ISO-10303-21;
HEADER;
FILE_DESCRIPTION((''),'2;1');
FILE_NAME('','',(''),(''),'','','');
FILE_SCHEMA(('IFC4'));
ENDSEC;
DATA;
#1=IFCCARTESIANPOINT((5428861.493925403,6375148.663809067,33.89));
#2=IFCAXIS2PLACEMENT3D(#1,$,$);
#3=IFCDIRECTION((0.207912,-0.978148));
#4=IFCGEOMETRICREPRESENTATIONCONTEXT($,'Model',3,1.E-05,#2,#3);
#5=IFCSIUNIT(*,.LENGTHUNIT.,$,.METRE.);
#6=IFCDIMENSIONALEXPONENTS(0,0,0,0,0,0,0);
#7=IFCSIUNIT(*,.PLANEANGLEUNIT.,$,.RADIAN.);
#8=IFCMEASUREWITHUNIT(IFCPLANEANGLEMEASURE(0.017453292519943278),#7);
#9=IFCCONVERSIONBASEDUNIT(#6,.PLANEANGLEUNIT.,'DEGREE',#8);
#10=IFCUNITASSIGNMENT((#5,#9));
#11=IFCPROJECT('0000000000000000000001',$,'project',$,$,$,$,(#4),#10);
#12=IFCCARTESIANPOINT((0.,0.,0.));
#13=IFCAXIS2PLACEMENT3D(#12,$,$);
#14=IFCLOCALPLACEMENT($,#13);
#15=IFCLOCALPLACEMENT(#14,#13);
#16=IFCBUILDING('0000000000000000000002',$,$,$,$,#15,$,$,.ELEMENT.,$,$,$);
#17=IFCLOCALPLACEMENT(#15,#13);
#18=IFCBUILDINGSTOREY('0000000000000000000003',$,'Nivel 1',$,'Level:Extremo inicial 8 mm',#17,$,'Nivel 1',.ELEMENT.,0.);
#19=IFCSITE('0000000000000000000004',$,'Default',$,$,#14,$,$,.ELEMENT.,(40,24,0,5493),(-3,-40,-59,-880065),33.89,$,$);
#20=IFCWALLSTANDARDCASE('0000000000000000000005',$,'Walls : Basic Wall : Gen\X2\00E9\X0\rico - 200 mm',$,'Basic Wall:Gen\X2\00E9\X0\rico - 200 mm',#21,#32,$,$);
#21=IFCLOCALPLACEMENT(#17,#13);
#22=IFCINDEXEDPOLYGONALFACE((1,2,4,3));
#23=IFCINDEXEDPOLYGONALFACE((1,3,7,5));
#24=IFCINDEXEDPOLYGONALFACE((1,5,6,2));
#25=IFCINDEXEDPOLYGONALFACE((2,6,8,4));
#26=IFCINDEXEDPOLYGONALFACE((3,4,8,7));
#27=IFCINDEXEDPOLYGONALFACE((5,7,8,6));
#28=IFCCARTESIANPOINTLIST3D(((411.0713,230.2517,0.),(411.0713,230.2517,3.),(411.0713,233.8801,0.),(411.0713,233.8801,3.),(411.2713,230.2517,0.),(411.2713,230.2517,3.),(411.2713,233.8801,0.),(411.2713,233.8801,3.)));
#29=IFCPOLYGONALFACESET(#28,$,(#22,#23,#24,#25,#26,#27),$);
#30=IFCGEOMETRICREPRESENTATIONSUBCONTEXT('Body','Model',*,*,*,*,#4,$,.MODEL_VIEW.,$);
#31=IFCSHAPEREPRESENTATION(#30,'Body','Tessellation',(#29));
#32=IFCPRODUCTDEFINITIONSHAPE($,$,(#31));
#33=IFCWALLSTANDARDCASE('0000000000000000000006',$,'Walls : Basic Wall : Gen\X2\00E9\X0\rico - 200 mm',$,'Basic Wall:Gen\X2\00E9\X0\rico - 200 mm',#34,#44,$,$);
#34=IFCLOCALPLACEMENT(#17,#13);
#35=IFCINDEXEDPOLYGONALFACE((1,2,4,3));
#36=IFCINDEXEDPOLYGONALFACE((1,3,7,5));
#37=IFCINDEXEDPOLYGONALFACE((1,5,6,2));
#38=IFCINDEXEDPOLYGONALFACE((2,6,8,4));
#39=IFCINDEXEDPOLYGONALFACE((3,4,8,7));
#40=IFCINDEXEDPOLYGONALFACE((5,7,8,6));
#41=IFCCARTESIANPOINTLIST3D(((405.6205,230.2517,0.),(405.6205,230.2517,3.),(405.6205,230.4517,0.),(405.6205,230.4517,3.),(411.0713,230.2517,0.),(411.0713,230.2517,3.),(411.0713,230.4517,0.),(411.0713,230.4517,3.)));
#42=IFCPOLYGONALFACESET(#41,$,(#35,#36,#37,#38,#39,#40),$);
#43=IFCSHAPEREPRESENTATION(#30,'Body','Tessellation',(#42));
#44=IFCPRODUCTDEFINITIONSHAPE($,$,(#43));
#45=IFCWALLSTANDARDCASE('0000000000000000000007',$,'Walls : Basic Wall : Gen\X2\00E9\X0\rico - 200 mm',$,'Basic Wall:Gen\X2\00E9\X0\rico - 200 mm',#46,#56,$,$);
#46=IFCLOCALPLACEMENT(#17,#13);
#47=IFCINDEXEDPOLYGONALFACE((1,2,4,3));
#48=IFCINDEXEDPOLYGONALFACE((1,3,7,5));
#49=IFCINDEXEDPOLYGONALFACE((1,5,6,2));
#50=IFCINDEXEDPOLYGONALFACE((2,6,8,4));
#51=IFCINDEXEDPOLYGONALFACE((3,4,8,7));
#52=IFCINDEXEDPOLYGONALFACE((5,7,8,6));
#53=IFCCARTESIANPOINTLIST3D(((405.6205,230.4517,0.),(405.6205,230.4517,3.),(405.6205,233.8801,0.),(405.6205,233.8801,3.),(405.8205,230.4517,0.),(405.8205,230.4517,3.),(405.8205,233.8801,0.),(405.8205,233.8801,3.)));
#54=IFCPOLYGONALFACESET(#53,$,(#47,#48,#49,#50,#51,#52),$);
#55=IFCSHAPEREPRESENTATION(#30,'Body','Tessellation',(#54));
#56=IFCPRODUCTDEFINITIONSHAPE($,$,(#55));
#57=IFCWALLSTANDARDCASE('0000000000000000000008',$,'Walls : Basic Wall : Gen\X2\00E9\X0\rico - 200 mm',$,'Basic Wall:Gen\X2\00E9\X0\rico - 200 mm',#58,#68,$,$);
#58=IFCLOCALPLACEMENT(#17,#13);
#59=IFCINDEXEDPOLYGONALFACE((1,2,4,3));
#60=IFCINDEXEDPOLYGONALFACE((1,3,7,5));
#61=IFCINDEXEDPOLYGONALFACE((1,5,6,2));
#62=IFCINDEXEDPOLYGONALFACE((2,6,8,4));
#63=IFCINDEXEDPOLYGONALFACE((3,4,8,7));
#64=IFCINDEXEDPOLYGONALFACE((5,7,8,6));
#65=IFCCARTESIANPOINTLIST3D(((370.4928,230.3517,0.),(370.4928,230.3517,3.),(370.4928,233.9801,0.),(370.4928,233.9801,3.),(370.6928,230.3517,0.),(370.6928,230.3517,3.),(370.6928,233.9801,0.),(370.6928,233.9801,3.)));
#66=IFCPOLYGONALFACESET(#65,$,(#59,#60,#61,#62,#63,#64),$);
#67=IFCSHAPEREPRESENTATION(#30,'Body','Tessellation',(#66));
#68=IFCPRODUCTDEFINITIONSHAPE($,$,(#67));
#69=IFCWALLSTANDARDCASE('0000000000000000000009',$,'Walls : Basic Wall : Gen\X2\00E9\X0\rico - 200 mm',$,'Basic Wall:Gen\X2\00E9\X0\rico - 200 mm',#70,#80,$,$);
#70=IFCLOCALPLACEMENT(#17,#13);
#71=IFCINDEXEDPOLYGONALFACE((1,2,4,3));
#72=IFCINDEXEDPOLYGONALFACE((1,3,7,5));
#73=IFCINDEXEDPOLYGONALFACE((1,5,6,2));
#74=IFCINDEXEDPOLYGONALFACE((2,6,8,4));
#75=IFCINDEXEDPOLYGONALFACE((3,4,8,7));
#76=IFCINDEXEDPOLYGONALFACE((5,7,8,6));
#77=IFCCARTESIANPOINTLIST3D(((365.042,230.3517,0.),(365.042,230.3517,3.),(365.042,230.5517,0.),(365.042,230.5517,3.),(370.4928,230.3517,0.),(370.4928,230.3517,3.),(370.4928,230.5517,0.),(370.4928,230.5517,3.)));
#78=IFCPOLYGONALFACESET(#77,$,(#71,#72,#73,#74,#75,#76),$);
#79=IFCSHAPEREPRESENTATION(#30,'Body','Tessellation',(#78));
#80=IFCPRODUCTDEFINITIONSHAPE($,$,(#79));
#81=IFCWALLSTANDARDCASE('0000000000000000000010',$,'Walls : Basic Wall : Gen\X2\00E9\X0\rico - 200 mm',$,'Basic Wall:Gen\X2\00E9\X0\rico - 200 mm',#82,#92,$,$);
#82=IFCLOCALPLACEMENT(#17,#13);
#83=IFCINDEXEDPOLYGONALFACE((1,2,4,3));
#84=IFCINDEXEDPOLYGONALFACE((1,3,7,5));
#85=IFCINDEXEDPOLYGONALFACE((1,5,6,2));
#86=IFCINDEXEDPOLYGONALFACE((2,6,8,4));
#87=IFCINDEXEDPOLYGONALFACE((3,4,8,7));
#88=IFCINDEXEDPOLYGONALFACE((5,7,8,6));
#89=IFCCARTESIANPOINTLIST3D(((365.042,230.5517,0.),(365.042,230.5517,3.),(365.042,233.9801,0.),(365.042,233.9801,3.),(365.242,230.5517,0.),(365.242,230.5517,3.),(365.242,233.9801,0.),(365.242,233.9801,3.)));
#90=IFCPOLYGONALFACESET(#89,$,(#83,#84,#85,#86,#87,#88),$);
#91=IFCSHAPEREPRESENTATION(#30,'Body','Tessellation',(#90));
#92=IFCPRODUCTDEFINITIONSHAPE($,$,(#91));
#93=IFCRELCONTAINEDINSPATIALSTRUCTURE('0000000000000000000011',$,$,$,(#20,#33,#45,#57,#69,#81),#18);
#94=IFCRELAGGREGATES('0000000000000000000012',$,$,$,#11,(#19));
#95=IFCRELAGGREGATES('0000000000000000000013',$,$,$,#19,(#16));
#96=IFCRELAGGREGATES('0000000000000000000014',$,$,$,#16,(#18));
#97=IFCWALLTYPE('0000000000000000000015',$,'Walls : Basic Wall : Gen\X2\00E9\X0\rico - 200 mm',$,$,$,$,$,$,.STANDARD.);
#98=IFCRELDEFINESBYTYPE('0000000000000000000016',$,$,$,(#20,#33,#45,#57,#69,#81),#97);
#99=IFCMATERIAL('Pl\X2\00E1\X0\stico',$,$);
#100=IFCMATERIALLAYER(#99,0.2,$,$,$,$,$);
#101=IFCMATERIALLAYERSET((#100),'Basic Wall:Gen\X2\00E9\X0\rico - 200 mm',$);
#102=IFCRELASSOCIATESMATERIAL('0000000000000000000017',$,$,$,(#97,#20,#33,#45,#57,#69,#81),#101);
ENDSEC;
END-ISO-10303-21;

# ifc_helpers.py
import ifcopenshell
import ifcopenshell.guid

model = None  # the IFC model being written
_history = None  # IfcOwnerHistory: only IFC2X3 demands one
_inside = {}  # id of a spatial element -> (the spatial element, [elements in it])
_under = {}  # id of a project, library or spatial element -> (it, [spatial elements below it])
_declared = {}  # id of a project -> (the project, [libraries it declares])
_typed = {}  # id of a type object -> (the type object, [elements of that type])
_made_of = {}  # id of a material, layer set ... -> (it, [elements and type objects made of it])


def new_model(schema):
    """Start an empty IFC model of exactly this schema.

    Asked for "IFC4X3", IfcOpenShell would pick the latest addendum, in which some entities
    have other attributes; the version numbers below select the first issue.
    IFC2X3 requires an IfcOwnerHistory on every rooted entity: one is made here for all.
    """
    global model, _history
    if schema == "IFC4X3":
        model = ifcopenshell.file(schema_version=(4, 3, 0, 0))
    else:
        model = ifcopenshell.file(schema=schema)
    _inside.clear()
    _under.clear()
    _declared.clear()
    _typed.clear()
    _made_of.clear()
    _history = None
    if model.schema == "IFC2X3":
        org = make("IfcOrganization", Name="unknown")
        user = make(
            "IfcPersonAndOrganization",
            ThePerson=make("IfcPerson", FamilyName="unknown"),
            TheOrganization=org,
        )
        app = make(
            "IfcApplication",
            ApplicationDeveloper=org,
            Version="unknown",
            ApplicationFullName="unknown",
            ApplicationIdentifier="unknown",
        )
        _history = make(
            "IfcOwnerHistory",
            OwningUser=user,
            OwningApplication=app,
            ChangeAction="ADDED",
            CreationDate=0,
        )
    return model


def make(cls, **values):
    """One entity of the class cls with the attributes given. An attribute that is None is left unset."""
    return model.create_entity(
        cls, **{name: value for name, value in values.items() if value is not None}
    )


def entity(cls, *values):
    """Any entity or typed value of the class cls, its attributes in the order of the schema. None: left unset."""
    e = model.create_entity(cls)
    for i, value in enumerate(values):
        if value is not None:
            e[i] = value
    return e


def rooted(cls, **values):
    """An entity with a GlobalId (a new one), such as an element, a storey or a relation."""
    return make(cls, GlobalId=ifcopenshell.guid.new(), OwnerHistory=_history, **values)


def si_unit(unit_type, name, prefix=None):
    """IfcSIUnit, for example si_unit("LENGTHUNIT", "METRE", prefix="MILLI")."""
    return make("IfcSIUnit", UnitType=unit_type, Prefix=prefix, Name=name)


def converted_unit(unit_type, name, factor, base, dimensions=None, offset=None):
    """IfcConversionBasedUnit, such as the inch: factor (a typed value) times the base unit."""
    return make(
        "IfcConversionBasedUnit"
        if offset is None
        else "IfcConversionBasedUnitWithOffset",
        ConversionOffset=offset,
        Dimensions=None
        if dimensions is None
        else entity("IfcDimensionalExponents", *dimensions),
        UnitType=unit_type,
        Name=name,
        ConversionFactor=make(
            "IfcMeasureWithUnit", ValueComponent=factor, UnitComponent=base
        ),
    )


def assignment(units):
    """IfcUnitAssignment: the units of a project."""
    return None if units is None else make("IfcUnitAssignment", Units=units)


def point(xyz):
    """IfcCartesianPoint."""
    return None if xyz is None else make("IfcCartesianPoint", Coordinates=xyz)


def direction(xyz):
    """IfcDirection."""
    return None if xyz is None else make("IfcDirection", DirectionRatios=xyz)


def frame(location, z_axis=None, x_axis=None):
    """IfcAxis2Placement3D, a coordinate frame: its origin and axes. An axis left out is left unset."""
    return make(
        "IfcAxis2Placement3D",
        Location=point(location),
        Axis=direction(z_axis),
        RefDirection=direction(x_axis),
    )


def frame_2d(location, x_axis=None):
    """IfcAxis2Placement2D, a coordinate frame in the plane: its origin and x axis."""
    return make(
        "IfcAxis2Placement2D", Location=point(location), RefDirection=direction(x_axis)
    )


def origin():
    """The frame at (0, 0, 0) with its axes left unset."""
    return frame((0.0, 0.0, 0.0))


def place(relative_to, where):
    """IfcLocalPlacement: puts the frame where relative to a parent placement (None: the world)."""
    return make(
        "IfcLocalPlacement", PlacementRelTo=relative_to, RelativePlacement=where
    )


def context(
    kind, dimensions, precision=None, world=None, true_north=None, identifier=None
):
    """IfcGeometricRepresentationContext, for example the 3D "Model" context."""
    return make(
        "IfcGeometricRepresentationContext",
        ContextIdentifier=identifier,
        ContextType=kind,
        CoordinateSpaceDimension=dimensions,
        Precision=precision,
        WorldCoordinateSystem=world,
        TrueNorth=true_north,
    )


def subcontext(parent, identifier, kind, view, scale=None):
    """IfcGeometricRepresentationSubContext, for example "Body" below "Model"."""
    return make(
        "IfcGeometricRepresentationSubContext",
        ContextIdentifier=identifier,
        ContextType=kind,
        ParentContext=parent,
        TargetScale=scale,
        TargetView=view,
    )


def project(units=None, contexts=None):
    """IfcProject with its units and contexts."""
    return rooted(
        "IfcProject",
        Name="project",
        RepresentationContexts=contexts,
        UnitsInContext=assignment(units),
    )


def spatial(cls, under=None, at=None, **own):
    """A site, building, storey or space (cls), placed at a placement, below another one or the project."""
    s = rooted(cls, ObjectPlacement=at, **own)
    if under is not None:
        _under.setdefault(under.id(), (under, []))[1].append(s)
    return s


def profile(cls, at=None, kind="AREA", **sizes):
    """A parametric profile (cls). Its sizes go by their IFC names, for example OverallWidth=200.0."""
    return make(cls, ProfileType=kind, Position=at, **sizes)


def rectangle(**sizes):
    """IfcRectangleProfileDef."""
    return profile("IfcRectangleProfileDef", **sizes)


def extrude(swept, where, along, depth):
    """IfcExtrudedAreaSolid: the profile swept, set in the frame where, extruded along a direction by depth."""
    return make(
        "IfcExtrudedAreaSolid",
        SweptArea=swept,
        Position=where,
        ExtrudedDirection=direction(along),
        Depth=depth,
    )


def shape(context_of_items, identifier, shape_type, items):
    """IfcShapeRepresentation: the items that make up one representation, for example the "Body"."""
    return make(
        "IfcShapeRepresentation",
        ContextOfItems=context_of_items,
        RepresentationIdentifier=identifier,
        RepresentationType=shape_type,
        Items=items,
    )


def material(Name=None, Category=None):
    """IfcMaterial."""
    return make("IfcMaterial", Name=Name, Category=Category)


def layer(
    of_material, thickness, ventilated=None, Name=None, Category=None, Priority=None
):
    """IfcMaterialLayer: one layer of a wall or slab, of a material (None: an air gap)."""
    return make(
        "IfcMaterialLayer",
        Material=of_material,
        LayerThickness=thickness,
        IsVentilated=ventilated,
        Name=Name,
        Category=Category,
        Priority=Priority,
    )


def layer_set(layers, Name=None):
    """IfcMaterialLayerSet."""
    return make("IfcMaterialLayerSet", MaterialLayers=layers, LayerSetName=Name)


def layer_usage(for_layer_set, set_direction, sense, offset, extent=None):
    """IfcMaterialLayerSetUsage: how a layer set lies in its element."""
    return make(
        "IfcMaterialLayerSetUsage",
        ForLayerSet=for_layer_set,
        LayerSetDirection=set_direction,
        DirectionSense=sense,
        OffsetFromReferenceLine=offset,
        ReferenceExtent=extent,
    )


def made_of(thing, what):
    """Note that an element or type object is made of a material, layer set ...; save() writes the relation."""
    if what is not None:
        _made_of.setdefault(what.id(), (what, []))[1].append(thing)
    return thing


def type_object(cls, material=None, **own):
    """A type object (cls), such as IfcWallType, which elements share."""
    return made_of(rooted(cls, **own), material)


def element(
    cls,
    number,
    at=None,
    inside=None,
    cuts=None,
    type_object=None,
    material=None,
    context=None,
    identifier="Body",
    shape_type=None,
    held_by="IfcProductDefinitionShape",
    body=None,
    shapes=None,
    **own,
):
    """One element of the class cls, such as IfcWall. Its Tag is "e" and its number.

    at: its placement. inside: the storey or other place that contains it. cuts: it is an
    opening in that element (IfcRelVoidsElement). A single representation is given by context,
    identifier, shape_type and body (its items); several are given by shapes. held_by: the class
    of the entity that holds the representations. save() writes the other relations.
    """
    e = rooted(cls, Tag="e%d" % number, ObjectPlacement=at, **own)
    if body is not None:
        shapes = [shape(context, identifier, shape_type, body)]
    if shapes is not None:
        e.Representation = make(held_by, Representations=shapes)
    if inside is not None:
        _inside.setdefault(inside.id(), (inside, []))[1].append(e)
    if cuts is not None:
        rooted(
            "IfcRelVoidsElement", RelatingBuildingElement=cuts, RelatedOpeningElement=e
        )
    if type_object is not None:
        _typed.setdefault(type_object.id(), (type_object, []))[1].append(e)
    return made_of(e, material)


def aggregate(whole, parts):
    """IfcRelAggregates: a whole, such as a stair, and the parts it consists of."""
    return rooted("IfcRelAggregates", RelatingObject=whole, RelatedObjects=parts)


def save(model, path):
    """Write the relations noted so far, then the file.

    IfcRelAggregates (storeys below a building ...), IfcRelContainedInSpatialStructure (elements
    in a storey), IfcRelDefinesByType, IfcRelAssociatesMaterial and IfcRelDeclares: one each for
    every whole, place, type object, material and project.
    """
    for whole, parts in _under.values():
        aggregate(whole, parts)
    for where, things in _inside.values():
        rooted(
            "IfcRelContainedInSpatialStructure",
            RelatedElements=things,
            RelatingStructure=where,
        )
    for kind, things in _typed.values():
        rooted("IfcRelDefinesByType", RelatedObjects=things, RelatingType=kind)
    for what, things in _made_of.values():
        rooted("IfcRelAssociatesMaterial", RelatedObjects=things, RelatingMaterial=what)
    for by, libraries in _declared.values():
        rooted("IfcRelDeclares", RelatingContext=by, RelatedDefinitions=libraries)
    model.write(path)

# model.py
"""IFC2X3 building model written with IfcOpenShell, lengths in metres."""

from ifc_helpers import new_model, entity, si_unit, converted_unit, direction, frame, frame_2d, origin, place, context, subcontext, project, spatial, rectangle, extrude, material, layer, layer_set, layer_usage, type_object, element, save


model = new_model("IFC2X3")

# Units and contexts
model_context = context("Model", 3, precision=1e-05, world=frame((5428861.493925403, 6375148.663809067, 33.89)), true_north=direction((0.207912, -0.978148)))
body_context = subcontext(model_context, "Body", "Model", "MODEL_VIEW")
ifc_project = project(units=[si_unit("LENGTHUNIT", "METRE"), converted_unit("PLANEANGLEUNIT", "DEGREE", entity("IfcPlaneAngleMeasure", 0.017453292519943278), si_unit("PLANEANGLEUNIT", "RADIAN"), dimensions=[0, 0, 0, 0, 0, 0, 0])], contexts=[model_context])

# Site, building, storey
site_placement = place(None, origin())
site = spatial("IfcSite", under=ifc_project, at=site_placement, Name="Default", CompositionType="ELEMENT", RefLatitude=(40, 24, 0, 5493), RefLongitude=(-3, -40, -59, -880065), RefElevation=33.89)
building_placement = place(site_placement, origin())
building = spatial("IfcBuilding", under=site, at=building_placement, CompositionType="ELEMENT")
storey_placement = place(building_placement, origin())
storey = spatial("IfcBuildingStorey", under=building, at=storey_placement, Name="Nivel 1", ObjectType="Level:Extremo inicial 8 mm", LongName="Nivel 1", CompositionType="ELEMENT", Elevation=0.0)

# Walls
ifc_material = material(Name="Plástico")
ifc_layer = layer(ifc_material, 0.2)
ifc_layer_set = layer_set([ifc_layer], Name="Basic Wall:Genérico - 200 mm")
wall_type = type_object("IfcWallType", Name="Walls : Basic Wall : Genérico - 200 mm", PredefinedType="STANDARD", material=ifc_layer_set)
ifc_layer_usage_1 = layer_usage(ifc_layer_set, "AXIS2", "NEGATIVE", 0.1)
wall_1_placement = place(storey_placement, frame((411.1713, 233.8801, 0.0), z_axis=(0.0, 0.0, 1.0), x_axis=(0.0, -1.0, 0.0)))
element("IfcWallStandardCase", 1, at=wall_1_placement, inside=storey, type_object=wall_type, material=ifc_layer_usage_1, Name="Walls : Basic Wall : Genérico - 200 mm", ObjectType="Basic Wall:Genérico - 200 mm", context=body_context, shape_type="SweptSolid", body=[
    extrude(rectangle(XDim=3.6285, YDim=0.2, at=frame_2d((1.8142, 0.0), x_axis=(-1.0, 0.0))), origin(), (0.0, 0.0, 1.0), 3.0),
])
ifc_layer_usage_2 = layer_usage(ifc_layer_set, "AXIS2", "NEGATIVE", 0.1)
wall_2_placement = place(storey_placement, frame((411.0713, 230.3517, 0.0), z_axis=(0.0, 0.0, 1.0), x_axis=(-1.0, 0.0, 0.0)))
element("IfcWallStandardCase", 2, at=wall_2_placement, inside=storey, type_object=wall_type, material=ifc_layer_usage_2, Name="Walls : Basic Wall : Genérico - 200 mm", ObjectType="Basic Wall:Genérico - 200 mm", context=body_context, shape_type="SweptSolid", body=[
    extrude(rectangle(XDim=5.4508, YDim=0.2, at=frame_2d((2.7254, 0.0), x_axis=(-1.0, 0.0))), origin(), (0.0, 0.0, 1.0), 3.0),
])
ifc_layer_usage_3 = layer_usage(ifc_layer_set, "AXIS2", "NEGATIVE", 0.1)
wall_3_placement = place(storey_placement, frame((405.7205, 230.4517, 0.0), z_axis=(0.0, 0.0, 1.0), x_axis=(0.0, 1.0, 0.0)))
element("IfcWallStandardCase", 3, at=wall_3_placement, inside=storey, type_object=wall_type, material=ifc_layer_usage_3, Name="Walls : Basic Wall : Genérico - 200 mm", ObjectType="Basic Wall:Genérico - 200 mm", context=body_context, shape_type="SweptSolid", body=[
    extrude(rectangle(XDim=3.4285, YDim=0.2, at=frame_2d((1.7142, 0.0), x_axis=(-1.0, 0.0))), origin(), (0.0, 0.0, 1.0), 3.0),
])
ifc_layer_usage_4 = layer_usage(ifc_layer_set, "AXIS2", "NEGATIVE", 0.1)
wall_4_placement = place(storey_placement, frame((370.5928, 233.9801, 0.0), z_axis=(0.0, 0.0, 1.0), x_axis=(0.0, -1.0, 0.0)))
element("IfcWallStandardCase", 4, at=wall_4_placement, inside=storey, type_object=wall_type, material=ifc_layer_usage_4, Name="Walls : Basic Wall : Genérico - 200 mm", ObjectType="Basic Wall:Genérico - 200 mm", context=body_context, shape_type="SweptSolid", body=[
    extrude(rectangle(XDim=3.6285, YDim=0.2, at=frame_2d((1.8142, 0.0), x_axis=(-1.0, 0.0))), origin(), (0.0, 0.0, 1.0), 3.0),
])
ifc_layer_usage_5 = layer_usage(ifc_layer_set, "AXIS2", "NEGATIVE", 0.1)
wall_5_placement = place(storey_placement, frame((370.4928, 230.4517, 0.0), z_axis=(0.0, 0.0, 1.0), x_axis=(-1.0, 0.0, 0.0)))
element("IfcWallStandardCase", 5, at=wall_5_placement, inside=storey, type_object=wall_type, material=ifc_layer_usage_5, Name="Walls : Basic Wall : Genérico - 200 mm", ObjectType="Basic Wall:Genérico - 200 mm", context=body_context, shape_type="SweptSolid", body=[
    extrude(rectangle(XDim=5.4508, YDim=0.2, at=frame_2d((2.7254, 0.0), x_axis=(-1.0, 0.0))), origin(), (0.0, 0.0, 1.0), 3.0),
])
ifc_layer_usage_6 = layer_usage(ifc_layer_set, "AXIS2", "NEGATIVE", 0.1)
wall_6_placement = place(storey_placement, frame((365.142, 230.5517, 0.0), z_axis=(0.0, 0.0, 1.0), x_axis=(0.0, 1.0, 0.0)))
element("IfcWallStandardCase", 6, at=wall_6_placement, inside=storey, type_object=wall_type, material=ifc_layer_usage_6, Name="Walls : Basic Wall : Genérico - 200 mm", ObjectType="Basic Wall:Genérico - 200 mm", context=body_context, shape_type="SweptSolid", body=[
    extrude(rectangle(XDim=3.4285, YDim=0.2, at=frame_2d((1.7142, 0.0), x_axis=(-1.0, 0.0))), origin(), (0.0, 0.0, 1.0), 3.0),
])

save(model, "model.ifc")
